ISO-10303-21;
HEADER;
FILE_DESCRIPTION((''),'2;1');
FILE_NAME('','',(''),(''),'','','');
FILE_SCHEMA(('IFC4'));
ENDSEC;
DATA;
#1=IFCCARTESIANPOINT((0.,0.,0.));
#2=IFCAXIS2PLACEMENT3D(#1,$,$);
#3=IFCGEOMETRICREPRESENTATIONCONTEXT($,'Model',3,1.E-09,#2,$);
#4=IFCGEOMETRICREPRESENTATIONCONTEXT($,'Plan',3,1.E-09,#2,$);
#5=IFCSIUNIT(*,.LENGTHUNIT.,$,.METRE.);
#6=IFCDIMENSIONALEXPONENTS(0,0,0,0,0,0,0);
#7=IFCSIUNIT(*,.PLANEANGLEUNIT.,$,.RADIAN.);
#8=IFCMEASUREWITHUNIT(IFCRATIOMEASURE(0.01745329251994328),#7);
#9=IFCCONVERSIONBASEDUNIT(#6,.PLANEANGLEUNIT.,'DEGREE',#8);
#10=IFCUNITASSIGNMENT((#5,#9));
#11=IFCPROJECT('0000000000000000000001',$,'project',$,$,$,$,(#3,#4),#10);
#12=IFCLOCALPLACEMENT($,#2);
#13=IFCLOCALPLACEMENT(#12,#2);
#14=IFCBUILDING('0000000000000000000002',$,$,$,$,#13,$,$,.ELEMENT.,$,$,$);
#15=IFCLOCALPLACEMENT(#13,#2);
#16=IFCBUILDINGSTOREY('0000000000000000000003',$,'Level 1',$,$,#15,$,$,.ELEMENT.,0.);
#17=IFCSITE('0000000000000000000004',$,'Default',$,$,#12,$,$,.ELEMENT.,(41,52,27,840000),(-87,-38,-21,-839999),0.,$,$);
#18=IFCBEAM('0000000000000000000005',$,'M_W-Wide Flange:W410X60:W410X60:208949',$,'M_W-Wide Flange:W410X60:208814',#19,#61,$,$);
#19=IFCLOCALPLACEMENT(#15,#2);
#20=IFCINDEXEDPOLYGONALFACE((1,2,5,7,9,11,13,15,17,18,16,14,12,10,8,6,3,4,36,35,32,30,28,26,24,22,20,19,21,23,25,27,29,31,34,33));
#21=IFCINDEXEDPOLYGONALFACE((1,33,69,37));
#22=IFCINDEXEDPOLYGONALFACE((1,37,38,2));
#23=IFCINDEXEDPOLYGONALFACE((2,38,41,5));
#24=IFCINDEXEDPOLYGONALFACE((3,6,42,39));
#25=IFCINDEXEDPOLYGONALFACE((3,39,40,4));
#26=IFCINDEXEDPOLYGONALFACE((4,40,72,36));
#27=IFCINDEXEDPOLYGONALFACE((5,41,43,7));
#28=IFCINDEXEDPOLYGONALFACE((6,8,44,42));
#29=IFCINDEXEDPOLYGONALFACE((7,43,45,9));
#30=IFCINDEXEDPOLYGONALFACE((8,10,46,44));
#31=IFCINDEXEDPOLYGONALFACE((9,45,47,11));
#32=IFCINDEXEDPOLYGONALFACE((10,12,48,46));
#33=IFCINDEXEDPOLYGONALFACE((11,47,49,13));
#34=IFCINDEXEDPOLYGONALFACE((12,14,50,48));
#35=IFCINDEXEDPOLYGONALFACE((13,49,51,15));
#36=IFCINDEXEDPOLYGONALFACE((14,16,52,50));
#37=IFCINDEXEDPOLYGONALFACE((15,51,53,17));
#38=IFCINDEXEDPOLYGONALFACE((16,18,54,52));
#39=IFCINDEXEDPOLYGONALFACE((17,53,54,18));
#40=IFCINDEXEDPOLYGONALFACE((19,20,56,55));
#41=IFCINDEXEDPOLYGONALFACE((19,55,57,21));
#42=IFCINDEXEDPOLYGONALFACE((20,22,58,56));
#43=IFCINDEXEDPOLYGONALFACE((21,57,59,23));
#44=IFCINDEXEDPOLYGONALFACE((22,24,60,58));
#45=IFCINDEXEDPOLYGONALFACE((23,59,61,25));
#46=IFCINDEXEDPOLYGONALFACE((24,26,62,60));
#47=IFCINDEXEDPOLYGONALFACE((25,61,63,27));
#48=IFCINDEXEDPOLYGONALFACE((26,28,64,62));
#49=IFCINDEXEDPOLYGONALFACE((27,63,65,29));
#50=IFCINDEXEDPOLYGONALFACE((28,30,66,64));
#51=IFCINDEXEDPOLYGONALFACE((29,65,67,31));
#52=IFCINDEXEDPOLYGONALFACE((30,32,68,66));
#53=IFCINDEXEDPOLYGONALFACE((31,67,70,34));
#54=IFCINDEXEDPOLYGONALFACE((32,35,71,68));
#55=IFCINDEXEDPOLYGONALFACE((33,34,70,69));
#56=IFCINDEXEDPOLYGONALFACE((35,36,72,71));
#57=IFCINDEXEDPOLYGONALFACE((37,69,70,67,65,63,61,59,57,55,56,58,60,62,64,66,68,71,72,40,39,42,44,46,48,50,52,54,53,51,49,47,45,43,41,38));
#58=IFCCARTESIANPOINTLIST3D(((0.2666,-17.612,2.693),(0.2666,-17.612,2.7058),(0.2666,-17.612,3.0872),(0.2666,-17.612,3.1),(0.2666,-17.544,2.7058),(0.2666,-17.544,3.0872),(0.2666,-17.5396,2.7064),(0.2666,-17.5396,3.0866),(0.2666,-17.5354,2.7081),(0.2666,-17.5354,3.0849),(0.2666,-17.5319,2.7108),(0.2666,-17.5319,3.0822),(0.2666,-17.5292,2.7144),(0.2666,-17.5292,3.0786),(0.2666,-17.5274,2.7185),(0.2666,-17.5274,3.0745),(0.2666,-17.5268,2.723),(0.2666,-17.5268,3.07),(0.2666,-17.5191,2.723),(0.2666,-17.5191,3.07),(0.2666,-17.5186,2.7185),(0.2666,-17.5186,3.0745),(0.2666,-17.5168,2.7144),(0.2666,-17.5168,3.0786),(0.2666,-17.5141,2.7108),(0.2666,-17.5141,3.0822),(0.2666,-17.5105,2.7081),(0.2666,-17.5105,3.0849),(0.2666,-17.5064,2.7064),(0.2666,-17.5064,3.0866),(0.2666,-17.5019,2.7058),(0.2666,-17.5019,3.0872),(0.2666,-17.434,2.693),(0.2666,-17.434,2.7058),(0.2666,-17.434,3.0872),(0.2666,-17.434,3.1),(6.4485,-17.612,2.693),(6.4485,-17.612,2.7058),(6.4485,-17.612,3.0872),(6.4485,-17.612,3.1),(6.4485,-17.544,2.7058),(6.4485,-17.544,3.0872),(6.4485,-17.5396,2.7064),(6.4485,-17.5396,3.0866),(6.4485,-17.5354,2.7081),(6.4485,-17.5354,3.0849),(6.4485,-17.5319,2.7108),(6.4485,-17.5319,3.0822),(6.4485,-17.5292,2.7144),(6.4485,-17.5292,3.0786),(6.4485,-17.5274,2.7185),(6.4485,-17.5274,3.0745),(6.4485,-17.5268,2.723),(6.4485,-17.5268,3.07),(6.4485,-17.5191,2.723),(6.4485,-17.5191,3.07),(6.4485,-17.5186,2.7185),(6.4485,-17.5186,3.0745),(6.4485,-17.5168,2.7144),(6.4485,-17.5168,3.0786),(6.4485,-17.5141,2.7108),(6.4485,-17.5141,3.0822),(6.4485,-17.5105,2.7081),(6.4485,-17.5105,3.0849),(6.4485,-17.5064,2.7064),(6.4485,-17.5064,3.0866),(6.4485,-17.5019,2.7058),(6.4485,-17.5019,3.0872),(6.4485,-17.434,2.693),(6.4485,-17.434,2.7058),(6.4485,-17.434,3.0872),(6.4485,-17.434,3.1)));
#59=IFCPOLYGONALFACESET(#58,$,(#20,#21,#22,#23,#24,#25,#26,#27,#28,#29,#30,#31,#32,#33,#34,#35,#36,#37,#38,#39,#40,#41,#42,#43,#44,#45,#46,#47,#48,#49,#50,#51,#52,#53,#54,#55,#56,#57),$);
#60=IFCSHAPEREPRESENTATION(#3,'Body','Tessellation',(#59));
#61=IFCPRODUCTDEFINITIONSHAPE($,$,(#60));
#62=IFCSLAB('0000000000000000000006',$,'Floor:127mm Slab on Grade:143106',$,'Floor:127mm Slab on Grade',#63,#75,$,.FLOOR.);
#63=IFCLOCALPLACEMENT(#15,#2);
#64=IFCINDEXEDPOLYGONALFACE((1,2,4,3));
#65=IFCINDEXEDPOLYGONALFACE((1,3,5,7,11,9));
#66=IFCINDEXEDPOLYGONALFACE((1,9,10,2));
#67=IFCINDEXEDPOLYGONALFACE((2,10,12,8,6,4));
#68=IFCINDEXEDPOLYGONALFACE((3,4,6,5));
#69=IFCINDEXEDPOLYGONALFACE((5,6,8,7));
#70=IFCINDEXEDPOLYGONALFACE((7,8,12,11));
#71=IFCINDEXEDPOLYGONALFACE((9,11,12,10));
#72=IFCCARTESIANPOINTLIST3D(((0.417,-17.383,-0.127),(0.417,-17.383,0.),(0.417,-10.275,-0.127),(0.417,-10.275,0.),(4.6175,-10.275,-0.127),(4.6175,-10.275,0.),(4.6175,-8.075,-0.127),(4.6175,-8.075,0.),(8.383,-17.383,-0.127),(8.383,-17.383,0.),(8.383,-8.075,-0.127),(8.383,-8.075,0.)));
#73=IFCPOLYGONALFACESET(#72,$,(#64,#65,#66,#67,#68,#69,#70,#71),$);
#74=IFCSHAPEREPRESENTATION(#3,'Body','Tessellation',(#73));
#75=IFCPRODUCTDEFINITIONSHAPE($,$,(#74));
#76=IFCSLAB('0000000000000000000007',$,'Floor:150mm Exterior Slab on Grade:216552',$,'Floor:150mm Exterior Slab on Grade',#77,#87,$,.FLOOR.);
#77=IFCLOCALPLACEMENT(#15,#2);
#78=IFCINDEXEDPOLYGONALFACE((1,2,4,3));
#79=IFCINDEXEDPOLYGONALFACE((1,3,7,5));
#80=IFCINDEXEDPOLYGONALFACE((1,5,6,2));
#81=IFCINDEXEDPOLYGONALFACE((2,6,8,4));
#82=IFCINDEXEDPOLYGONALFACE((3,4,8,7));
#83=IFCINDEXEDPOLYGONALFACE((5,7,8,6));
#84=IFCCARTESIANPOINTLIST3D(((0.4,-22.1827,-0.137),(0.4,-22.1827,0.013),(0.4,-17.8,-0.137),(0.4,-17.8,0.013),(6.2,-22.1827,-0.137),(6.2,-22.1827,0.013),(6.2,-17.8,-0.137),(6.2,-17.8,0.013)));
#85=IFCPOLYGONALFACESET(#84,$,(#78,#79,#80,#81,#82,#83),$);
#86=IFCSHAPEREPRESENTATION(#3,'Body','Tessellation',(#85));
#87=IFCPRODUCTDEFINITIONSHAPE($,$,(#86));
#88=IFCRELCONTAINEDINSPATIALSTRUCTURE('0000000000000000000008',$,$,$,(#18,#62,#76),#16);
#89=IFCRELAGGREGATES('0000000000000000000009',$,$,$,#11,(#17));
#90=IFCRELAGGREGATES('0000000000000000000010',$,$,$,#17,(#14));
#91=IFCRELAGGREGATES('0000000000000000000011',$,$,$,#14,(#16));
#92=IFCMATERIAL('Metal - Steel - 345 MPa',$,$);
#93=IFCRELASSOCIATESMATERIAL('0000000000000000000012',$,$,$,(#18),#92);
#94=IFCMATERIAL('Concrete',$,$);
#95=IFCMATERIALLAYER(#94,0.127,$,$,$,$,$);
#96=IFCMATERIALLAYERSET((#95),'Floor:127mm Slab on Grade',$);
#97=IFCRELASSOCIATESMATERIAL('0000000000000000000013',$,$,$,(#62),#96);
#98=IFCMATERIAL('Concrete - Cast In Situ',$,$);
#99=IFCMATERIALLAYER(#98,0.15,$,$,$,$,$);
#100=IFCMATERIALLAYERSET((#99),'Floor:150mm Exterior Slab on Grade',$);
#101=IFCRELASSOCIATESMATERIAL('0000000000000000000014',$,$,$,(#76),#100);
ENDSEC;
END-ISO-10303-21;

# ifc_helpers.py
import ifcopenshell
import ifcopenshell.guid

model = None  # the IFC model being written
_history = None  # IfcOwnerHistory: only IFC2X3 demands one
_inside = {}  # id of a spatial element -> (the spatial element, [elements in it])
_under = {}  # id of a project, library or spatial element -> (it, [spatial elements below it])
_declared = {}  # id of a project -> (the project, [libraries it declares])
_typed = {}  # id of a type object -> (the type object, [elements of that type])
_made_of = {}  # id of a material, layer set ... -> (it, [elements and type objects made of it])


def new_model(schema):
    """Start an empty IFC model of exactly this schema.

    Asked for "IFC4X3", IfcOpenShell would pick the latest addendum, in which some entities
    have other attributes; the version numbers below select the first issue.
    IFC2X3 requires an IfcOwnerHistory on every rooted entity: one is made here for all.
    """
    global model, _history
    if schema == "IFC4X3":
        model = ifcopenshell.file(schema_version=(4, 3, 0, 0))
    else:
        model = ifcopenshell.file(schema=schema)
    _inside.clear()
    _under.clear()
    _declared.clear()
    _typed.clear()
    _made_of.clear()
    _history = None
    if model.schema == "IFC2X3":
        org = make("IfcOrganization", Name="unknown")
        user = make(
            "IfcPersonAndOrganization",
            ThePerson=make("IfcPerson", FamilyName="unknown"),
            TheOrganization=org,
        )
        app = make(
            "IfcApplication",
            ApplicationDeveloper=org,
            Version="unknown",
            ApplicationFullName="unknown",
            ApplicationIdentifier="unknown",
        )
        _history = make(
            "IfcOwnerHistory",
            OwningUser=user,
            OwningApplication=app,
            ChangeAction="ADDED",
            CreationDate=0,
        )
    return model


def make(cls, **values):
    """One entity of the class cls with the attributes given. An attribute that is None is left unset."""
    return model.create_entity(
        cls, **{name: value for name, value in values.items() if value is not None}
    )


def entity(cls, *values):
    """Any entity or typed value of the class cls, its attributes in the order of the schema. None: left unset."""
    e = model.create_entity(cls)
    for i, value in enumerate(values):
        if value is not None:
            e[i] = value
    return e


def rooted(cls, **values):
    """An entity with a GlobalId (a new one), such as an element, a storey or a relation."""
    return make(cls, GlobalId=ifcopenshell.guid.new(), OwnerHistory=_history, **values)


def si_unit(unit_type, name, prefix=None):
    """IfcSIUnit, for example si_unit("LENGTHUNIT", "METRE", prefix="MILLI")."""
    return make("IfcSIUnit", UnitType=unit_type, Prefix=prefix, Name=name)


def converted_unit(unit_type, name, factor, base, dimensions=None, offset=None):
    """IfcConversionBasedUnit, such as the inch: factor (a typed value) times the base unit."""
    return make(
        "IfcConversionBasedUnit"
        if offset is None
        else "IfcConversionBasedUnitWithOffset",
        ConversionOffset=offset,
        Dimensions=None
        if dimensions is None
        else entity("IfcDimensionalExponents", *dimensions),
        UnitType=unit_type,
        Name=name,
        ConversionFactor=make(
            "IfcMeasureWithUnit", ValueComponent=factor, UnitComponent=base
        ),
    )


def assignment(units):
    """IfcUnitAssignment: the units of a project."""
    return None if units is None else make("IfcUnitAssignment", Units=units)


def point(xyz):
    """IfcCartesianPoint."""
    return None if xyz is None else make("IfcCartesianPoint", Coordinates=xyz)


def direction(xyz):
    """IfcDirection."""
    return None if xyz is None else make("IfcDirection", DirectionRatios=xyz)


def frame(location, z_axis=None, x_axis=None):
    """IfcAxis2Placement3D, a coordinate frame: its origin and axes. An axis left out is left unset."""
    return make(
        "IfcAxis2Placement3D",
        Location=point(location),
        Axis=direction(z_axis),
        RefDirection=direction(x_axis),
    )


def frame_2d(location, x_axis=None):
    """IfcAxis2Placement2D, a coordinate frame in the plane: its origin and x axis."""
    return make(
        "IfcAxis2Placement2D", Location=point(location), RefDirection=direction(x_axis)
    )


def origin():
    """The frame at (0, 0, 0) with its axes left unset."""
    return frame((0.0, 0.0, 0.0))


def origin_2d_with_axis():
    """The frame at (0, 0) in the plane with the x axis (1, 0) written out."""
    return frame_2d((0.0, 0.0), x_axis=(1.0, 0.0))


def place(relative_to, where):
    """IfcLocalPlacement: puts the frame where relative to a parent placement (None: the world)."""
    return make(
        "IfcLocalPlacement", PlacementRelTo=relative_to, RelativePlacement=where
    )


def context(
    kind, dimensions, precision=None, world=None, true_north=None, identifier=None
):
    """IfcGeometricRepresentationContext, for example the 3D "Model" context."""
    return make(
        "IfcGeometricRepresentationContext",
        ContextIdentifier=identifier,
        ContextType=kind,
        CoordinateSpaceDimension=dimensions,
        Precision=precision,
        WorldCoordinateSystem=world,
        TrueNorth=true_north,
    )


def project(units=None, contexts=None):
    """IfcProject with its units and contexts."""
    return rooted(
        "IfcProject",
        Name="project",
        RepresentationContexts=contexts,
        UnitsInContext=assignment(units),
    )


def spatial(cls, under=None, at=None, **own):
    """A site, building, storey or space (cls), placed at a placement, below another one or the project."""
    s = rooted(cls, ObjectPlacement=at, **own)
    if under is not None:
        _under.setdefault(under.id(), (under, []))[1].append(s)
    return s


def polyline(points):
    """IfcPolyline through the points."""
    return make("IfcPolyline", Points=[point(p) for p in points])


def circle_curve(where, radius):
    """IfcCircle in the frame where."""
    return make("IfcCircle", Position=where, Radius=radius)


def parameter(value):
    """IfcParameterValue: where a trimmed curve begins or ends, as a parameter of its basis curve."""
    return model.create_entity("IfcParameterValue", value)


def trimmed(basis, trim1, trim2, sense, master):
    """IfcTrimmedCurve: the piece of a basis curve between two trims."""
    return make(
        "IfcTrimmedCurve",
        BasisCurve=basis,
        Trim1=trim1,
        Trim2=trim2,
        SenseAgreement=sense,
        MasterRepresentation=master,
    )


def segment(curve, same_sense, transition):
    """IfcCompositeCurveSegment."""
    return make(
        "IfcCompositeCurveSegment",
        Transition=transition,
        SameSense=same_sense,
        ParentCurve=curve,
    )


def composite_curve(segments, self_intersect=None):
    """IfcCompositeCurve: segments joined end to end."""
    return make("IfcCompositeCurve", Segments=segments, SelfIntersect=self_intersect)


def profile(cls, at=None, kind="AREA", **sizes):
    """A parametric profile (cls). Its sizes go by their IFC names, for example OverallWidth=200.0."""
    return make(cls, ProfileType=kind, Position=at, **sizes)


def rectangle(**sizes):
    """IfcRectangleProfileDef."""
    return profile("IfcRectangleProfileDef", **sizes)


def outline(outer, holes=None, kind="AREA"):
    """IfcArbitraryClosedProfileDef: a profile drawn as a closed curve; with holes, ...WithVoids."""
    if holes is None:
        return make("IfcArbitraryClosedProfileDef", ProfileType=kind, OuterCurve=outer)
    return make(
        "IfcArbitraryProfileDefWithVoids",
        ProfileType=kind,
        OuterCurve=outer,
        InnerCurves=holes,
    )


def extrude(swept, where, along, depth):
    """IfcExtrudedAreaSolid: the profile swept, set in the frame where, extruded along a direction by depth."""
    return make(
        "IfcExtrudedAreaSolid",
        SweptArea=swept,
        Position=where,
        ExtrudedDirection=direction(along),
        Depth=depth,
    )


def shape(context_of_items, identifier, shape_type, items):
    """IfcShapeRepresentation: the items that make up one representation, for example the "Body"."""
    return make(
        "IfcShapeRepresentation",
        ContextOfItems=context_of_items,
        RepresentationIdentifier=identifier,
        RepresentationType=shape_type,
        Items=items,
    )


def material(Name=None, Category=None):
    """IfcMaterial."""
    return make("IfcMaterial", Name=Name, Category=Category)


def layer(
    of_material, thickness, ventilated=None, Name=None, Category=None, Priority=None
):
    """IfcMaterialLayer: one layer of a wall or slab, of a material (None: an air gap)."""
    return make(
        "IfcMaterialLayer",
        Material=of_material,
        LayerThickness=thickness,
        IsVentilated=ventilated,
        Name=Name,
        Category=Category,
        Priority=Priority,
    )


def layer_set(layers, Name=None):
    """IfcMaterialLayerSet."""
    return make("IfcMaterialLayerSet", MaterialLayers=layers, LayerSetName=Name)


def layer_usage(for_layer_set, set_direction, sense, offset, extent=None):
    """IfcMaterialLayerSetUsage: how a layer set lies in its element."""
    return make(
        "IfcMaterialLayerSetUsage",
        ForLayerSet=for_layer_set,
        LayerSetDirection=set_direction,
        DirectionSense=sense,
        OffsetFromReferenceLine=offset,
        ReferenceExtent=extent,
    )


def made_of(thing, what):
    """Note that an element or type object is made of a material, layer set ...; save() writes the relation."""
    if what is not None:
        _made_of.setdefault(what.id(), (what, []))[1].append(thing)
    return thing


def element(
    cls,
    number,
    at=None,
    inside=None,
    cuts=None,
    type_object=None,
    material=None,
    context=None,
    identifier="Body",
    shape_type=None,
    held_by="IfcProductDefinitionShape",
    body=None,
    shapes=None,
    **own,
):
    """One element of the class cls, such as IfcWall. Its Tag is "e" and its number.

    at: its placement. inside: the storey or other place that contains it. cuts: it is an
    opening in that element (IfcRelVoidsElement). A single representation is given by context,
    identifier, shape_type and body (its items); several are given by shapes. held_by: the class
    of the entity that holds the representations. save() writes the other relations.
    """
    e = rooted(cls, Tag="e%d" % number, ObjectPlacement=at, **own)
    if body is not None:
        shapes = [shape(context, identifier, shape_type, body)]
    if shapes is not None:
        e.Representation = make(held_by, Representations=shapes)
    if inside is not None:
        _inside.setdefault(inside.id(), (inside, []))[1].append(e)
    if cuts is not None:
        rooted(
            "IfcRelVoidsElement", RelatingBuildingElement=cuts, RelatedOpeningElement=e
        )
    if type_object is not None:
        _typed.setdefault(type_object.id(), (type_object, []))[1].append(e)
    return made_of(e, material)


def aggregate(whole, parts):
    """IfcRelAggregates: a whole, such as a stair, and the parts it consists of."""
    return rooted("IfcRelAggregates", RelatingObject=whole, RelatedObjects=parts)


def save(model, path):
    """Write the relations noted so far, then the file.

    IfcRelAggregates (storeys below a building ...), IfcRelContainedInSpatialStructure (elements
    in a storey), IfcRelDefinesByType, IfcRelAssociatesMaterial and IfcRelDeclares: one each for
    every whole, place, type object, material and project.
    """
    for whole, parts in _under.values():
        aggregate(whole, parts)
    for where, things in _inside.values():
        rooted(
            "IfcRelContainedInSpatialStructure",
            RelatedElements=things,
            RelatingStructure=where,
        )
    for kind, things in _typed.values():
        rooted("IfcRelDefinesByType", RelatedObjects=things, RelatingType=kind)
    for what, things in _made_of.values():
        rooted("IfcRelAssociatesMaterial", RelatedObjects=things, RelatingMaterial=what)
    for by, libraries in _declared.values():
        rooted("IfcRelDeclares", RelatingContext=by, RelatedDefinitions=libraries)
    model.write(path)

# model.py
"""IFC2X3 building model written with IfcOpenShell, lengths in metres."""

from ifc_helpers import new_model, entity, si_unit, converted_unit, frame, frame_2d, origin, origin_2d_with_axis, place, context, project, spatial, polyline, circle_curve, parameter, trimmed, segment, composite_curve, rectangle, outline, extrude, material, layer, layer_set, layer_usage, element, save


model = new_model("IFC2X3")

# Units and contexts
model_context = context("Model", 3, precision=1e-09, world=origin())
plan_context = context("Plan", 3, precision=1e-09, world=origin())
ifc_project = project(units=[si_unit("LENGTHUNIT", "METRE"), converted_unit("PLANEANGLEUNIT", "DEGREE", entity("IfcRatioMeasure", 0.01745329251994328), si_unit("PLANEANGLEUNIT", "RADIAN"), dimensions=[0, 0, 0, 0, 0, 0, 0])], contexts=[model_context, plan_context])

# Site, building, storey
site_placement = place(None, origin())
site = spatial("IfcSite", under=ifc_project, at=site_placement, Name="Default", CompositionType="ELEMENT", RefLatitude=(41, 52, 27, 840000), RefLongitude=(-87, -38, -21, -839999), RefElevation=0.0)
building_placement = place(site_placement, origin())
building = spatial("IfcBuilding", under=site, at=building_placement, CompositionType="ELEMENT")
storey_placement = place(building_placement, origin())
storey = spatial("IfcBuildingStorey", under=building, at=storey_placement, Name="Level 1", CompositionType="ELEMENT", Elevation=0.0)

# Beam
ifc_material_1 = material(Name="Metal - Steel - 345 MPa")
beam_placement = place(storey_placement, frame((0.2085, -17.523, 3.1), z_axis=(0.0, 0.0, 1.0), x_axis=(0.0, -1.0, 0.0)))
element("IfcBeam", 1, at=beam_placement, inside=storey, material=ifc_material_1, Name="M_W-Wide Flange:W410X60:W410X60:208949", ObjectType="M_W-Wide Flange:W410X60:208814", context=model_context, shape_type="SweptSolid", body=[
    extrude(outline(composite_curve([segment(polyline([(-0.089, -0.1907), (-0.089, -0.2035)]), True, "CONTINUOUS"), segment(polyline([(-0.089, -0.2035), (0.089, -0.2035)]), True, "CONTINUOUS"), segment(polyline([(0.089, -0.2035), (0.089, -0.1907)]), True, "CONTINUOUS"), segment(polyline([(0.089, -0.1907), (0.021, -0.1907)]), True, "CONTINUOUS"), segment(trimmed(circle_curve(frame_2d((0.021, -0.1735), x_axis=(0.0, -1.0)), 0.0172), [parameter(270.0)], [parameter(360.0)], True, "PARAMETER"), False, "CONTINUOUS"), segment(polyline([(0.0038, -0.1735), (0.0038, 0.1735)]), True, "CONTINUOUS"), segment(trimmed(circle_curve(frame_2d((0.021, 0.1735), x_axis=(-1.0, 0.0)), 0.0172), [parameter(270.0)], [parameter(360.0)], True, "PARAMETER"), False, "CONTINUOUS"), segment(polyline([(0.021, 0.1907), (0.089, 0.1907)]), True, "CONTINUOUS"), segment(polyline([(0.089, 0.1907), (0.089, 0.2035)]), True, "CONTINUOUS"), segment(polyline([(0.089, 0.2035), (-0.089, 0.2035)]), True, "CONTINUOUS"), segment(polyline([(-0.089, 0.2035), (-0.089, 0.1907)]), True, "CONTINUOUS"), segment(polyline([(-0.089, 0.1907), (-0.0211, 0.1907)]), True, "CONTINUOUS"), segment(trimmed(circle_curve(frame_2d((-0.0211, 0.1735), x_axis=(0.0, 1.0)), 0.0172), [parameter(270.0)], [parameter(0.0)], True, "PARAMETER"), False, "CONTINUOUS"), segment(polyline([(-0.0039, 0.1735), (-0.0039, -0.1735)]), True, "CONTINUOUS"), segment(trimmed(circle_curve(frame_2d((-0.0211, -0.1735), x_axis=(1.0, 0.0)), 0.0172), [parameter(270.0)], [parameter(0.0)], True, "PARAMETER"), False, "CONTINUOUS"), segment(polyline([(-0.0211, -0.1907), (-0.089, -0.1907)]), True, "CONTINUOUS")], self_intersect=False)), frame((0.0, 0.0581, -0.2035), z_axis=(0.0, -1.0, 0.0), x_axis=(1.0, 0.0, 0.0)), (0.0, 0.0, -1.0), 6.1819),
])

# Slabs
ifc_material_2 = material(Name="Concrete")
ifc_layer_1 = layer(ifc_material_2, 0.127)
ifc_layer_set_1 = layer_set([ifc_layer_1], Name="Floor:127mm Slab on Grade")
ifc_layer_usage_1 = layer_usage(ifc_layer_set_1, "AXIS3", "POSITIVE", 0.0)
slab_1_placement = place(storey_placement, frame((0.417, -17.383, -0.127)))
element("IfcSlab", 2, at=slab_1_placement, inside=storey, material=ifc_layer_usage_1, Name="Floor:127mm Slab on Grade:143106", ObjectType="Floor:127mm Slab on Grade", PredefinedType="FLOOR", context=model_context, shape_type="SweptSolid", body=[
    extrude(outline(polyline([(-3.983, 4.654), (-3.983, -4.654), (3.983, -4.654), (3.983, 2.454), (-0.2175, 2.454), (-0.2175, 4.654), (-3.983, 4.654)])), frame((3.983, 4.654, 0.127), z_axis=(0.0, 0.0, -1.0), x_axis=(-1.0, 0.0, 0.0)), (0.0, 0.0, 1.0), 0.127),
])
ifc_material_3 = material(Name="Concrete - Cast In Situ")
ifc_layer_2 = layer(ifc_material_3, 0.15)
ifc_layer_set_2 = layer_set([ifc_layer_2], Name="Floor:150mm Exterior Slab on Grade")
ifc_layer_usage_2 = layer_usage(ifc_layer_set_2, "AXIS3", "POSITIVE", 0.0)
slab_2_placement = place(storey_placement, frame((0.4, -22.1827, -0.137)))
element("IfcSlab", 3, at=slab_2_placement, inside=storey, material=ifc_layer_usage_2, Name="Floor:150mm Exterior Slab on Grade:216552", ObjectType="Floor:150mm Exterior Slab on Grade", PredefinedType="FLOOR", context=model_context, shape_type="SweptSolid", body=[
    extrude(rectangle(XDim=5.8, YDim=4.3827, at=origin_2d_with_axis()), frame((2.9, 2.1914, 0.15), z_axis=(0.0, 0.0, -1.0), x_axis=(-1.0, 0.0, 0.0)), (0.0, 0.0, 1.0), 0.15),
])

save(model, "model.ifc")
